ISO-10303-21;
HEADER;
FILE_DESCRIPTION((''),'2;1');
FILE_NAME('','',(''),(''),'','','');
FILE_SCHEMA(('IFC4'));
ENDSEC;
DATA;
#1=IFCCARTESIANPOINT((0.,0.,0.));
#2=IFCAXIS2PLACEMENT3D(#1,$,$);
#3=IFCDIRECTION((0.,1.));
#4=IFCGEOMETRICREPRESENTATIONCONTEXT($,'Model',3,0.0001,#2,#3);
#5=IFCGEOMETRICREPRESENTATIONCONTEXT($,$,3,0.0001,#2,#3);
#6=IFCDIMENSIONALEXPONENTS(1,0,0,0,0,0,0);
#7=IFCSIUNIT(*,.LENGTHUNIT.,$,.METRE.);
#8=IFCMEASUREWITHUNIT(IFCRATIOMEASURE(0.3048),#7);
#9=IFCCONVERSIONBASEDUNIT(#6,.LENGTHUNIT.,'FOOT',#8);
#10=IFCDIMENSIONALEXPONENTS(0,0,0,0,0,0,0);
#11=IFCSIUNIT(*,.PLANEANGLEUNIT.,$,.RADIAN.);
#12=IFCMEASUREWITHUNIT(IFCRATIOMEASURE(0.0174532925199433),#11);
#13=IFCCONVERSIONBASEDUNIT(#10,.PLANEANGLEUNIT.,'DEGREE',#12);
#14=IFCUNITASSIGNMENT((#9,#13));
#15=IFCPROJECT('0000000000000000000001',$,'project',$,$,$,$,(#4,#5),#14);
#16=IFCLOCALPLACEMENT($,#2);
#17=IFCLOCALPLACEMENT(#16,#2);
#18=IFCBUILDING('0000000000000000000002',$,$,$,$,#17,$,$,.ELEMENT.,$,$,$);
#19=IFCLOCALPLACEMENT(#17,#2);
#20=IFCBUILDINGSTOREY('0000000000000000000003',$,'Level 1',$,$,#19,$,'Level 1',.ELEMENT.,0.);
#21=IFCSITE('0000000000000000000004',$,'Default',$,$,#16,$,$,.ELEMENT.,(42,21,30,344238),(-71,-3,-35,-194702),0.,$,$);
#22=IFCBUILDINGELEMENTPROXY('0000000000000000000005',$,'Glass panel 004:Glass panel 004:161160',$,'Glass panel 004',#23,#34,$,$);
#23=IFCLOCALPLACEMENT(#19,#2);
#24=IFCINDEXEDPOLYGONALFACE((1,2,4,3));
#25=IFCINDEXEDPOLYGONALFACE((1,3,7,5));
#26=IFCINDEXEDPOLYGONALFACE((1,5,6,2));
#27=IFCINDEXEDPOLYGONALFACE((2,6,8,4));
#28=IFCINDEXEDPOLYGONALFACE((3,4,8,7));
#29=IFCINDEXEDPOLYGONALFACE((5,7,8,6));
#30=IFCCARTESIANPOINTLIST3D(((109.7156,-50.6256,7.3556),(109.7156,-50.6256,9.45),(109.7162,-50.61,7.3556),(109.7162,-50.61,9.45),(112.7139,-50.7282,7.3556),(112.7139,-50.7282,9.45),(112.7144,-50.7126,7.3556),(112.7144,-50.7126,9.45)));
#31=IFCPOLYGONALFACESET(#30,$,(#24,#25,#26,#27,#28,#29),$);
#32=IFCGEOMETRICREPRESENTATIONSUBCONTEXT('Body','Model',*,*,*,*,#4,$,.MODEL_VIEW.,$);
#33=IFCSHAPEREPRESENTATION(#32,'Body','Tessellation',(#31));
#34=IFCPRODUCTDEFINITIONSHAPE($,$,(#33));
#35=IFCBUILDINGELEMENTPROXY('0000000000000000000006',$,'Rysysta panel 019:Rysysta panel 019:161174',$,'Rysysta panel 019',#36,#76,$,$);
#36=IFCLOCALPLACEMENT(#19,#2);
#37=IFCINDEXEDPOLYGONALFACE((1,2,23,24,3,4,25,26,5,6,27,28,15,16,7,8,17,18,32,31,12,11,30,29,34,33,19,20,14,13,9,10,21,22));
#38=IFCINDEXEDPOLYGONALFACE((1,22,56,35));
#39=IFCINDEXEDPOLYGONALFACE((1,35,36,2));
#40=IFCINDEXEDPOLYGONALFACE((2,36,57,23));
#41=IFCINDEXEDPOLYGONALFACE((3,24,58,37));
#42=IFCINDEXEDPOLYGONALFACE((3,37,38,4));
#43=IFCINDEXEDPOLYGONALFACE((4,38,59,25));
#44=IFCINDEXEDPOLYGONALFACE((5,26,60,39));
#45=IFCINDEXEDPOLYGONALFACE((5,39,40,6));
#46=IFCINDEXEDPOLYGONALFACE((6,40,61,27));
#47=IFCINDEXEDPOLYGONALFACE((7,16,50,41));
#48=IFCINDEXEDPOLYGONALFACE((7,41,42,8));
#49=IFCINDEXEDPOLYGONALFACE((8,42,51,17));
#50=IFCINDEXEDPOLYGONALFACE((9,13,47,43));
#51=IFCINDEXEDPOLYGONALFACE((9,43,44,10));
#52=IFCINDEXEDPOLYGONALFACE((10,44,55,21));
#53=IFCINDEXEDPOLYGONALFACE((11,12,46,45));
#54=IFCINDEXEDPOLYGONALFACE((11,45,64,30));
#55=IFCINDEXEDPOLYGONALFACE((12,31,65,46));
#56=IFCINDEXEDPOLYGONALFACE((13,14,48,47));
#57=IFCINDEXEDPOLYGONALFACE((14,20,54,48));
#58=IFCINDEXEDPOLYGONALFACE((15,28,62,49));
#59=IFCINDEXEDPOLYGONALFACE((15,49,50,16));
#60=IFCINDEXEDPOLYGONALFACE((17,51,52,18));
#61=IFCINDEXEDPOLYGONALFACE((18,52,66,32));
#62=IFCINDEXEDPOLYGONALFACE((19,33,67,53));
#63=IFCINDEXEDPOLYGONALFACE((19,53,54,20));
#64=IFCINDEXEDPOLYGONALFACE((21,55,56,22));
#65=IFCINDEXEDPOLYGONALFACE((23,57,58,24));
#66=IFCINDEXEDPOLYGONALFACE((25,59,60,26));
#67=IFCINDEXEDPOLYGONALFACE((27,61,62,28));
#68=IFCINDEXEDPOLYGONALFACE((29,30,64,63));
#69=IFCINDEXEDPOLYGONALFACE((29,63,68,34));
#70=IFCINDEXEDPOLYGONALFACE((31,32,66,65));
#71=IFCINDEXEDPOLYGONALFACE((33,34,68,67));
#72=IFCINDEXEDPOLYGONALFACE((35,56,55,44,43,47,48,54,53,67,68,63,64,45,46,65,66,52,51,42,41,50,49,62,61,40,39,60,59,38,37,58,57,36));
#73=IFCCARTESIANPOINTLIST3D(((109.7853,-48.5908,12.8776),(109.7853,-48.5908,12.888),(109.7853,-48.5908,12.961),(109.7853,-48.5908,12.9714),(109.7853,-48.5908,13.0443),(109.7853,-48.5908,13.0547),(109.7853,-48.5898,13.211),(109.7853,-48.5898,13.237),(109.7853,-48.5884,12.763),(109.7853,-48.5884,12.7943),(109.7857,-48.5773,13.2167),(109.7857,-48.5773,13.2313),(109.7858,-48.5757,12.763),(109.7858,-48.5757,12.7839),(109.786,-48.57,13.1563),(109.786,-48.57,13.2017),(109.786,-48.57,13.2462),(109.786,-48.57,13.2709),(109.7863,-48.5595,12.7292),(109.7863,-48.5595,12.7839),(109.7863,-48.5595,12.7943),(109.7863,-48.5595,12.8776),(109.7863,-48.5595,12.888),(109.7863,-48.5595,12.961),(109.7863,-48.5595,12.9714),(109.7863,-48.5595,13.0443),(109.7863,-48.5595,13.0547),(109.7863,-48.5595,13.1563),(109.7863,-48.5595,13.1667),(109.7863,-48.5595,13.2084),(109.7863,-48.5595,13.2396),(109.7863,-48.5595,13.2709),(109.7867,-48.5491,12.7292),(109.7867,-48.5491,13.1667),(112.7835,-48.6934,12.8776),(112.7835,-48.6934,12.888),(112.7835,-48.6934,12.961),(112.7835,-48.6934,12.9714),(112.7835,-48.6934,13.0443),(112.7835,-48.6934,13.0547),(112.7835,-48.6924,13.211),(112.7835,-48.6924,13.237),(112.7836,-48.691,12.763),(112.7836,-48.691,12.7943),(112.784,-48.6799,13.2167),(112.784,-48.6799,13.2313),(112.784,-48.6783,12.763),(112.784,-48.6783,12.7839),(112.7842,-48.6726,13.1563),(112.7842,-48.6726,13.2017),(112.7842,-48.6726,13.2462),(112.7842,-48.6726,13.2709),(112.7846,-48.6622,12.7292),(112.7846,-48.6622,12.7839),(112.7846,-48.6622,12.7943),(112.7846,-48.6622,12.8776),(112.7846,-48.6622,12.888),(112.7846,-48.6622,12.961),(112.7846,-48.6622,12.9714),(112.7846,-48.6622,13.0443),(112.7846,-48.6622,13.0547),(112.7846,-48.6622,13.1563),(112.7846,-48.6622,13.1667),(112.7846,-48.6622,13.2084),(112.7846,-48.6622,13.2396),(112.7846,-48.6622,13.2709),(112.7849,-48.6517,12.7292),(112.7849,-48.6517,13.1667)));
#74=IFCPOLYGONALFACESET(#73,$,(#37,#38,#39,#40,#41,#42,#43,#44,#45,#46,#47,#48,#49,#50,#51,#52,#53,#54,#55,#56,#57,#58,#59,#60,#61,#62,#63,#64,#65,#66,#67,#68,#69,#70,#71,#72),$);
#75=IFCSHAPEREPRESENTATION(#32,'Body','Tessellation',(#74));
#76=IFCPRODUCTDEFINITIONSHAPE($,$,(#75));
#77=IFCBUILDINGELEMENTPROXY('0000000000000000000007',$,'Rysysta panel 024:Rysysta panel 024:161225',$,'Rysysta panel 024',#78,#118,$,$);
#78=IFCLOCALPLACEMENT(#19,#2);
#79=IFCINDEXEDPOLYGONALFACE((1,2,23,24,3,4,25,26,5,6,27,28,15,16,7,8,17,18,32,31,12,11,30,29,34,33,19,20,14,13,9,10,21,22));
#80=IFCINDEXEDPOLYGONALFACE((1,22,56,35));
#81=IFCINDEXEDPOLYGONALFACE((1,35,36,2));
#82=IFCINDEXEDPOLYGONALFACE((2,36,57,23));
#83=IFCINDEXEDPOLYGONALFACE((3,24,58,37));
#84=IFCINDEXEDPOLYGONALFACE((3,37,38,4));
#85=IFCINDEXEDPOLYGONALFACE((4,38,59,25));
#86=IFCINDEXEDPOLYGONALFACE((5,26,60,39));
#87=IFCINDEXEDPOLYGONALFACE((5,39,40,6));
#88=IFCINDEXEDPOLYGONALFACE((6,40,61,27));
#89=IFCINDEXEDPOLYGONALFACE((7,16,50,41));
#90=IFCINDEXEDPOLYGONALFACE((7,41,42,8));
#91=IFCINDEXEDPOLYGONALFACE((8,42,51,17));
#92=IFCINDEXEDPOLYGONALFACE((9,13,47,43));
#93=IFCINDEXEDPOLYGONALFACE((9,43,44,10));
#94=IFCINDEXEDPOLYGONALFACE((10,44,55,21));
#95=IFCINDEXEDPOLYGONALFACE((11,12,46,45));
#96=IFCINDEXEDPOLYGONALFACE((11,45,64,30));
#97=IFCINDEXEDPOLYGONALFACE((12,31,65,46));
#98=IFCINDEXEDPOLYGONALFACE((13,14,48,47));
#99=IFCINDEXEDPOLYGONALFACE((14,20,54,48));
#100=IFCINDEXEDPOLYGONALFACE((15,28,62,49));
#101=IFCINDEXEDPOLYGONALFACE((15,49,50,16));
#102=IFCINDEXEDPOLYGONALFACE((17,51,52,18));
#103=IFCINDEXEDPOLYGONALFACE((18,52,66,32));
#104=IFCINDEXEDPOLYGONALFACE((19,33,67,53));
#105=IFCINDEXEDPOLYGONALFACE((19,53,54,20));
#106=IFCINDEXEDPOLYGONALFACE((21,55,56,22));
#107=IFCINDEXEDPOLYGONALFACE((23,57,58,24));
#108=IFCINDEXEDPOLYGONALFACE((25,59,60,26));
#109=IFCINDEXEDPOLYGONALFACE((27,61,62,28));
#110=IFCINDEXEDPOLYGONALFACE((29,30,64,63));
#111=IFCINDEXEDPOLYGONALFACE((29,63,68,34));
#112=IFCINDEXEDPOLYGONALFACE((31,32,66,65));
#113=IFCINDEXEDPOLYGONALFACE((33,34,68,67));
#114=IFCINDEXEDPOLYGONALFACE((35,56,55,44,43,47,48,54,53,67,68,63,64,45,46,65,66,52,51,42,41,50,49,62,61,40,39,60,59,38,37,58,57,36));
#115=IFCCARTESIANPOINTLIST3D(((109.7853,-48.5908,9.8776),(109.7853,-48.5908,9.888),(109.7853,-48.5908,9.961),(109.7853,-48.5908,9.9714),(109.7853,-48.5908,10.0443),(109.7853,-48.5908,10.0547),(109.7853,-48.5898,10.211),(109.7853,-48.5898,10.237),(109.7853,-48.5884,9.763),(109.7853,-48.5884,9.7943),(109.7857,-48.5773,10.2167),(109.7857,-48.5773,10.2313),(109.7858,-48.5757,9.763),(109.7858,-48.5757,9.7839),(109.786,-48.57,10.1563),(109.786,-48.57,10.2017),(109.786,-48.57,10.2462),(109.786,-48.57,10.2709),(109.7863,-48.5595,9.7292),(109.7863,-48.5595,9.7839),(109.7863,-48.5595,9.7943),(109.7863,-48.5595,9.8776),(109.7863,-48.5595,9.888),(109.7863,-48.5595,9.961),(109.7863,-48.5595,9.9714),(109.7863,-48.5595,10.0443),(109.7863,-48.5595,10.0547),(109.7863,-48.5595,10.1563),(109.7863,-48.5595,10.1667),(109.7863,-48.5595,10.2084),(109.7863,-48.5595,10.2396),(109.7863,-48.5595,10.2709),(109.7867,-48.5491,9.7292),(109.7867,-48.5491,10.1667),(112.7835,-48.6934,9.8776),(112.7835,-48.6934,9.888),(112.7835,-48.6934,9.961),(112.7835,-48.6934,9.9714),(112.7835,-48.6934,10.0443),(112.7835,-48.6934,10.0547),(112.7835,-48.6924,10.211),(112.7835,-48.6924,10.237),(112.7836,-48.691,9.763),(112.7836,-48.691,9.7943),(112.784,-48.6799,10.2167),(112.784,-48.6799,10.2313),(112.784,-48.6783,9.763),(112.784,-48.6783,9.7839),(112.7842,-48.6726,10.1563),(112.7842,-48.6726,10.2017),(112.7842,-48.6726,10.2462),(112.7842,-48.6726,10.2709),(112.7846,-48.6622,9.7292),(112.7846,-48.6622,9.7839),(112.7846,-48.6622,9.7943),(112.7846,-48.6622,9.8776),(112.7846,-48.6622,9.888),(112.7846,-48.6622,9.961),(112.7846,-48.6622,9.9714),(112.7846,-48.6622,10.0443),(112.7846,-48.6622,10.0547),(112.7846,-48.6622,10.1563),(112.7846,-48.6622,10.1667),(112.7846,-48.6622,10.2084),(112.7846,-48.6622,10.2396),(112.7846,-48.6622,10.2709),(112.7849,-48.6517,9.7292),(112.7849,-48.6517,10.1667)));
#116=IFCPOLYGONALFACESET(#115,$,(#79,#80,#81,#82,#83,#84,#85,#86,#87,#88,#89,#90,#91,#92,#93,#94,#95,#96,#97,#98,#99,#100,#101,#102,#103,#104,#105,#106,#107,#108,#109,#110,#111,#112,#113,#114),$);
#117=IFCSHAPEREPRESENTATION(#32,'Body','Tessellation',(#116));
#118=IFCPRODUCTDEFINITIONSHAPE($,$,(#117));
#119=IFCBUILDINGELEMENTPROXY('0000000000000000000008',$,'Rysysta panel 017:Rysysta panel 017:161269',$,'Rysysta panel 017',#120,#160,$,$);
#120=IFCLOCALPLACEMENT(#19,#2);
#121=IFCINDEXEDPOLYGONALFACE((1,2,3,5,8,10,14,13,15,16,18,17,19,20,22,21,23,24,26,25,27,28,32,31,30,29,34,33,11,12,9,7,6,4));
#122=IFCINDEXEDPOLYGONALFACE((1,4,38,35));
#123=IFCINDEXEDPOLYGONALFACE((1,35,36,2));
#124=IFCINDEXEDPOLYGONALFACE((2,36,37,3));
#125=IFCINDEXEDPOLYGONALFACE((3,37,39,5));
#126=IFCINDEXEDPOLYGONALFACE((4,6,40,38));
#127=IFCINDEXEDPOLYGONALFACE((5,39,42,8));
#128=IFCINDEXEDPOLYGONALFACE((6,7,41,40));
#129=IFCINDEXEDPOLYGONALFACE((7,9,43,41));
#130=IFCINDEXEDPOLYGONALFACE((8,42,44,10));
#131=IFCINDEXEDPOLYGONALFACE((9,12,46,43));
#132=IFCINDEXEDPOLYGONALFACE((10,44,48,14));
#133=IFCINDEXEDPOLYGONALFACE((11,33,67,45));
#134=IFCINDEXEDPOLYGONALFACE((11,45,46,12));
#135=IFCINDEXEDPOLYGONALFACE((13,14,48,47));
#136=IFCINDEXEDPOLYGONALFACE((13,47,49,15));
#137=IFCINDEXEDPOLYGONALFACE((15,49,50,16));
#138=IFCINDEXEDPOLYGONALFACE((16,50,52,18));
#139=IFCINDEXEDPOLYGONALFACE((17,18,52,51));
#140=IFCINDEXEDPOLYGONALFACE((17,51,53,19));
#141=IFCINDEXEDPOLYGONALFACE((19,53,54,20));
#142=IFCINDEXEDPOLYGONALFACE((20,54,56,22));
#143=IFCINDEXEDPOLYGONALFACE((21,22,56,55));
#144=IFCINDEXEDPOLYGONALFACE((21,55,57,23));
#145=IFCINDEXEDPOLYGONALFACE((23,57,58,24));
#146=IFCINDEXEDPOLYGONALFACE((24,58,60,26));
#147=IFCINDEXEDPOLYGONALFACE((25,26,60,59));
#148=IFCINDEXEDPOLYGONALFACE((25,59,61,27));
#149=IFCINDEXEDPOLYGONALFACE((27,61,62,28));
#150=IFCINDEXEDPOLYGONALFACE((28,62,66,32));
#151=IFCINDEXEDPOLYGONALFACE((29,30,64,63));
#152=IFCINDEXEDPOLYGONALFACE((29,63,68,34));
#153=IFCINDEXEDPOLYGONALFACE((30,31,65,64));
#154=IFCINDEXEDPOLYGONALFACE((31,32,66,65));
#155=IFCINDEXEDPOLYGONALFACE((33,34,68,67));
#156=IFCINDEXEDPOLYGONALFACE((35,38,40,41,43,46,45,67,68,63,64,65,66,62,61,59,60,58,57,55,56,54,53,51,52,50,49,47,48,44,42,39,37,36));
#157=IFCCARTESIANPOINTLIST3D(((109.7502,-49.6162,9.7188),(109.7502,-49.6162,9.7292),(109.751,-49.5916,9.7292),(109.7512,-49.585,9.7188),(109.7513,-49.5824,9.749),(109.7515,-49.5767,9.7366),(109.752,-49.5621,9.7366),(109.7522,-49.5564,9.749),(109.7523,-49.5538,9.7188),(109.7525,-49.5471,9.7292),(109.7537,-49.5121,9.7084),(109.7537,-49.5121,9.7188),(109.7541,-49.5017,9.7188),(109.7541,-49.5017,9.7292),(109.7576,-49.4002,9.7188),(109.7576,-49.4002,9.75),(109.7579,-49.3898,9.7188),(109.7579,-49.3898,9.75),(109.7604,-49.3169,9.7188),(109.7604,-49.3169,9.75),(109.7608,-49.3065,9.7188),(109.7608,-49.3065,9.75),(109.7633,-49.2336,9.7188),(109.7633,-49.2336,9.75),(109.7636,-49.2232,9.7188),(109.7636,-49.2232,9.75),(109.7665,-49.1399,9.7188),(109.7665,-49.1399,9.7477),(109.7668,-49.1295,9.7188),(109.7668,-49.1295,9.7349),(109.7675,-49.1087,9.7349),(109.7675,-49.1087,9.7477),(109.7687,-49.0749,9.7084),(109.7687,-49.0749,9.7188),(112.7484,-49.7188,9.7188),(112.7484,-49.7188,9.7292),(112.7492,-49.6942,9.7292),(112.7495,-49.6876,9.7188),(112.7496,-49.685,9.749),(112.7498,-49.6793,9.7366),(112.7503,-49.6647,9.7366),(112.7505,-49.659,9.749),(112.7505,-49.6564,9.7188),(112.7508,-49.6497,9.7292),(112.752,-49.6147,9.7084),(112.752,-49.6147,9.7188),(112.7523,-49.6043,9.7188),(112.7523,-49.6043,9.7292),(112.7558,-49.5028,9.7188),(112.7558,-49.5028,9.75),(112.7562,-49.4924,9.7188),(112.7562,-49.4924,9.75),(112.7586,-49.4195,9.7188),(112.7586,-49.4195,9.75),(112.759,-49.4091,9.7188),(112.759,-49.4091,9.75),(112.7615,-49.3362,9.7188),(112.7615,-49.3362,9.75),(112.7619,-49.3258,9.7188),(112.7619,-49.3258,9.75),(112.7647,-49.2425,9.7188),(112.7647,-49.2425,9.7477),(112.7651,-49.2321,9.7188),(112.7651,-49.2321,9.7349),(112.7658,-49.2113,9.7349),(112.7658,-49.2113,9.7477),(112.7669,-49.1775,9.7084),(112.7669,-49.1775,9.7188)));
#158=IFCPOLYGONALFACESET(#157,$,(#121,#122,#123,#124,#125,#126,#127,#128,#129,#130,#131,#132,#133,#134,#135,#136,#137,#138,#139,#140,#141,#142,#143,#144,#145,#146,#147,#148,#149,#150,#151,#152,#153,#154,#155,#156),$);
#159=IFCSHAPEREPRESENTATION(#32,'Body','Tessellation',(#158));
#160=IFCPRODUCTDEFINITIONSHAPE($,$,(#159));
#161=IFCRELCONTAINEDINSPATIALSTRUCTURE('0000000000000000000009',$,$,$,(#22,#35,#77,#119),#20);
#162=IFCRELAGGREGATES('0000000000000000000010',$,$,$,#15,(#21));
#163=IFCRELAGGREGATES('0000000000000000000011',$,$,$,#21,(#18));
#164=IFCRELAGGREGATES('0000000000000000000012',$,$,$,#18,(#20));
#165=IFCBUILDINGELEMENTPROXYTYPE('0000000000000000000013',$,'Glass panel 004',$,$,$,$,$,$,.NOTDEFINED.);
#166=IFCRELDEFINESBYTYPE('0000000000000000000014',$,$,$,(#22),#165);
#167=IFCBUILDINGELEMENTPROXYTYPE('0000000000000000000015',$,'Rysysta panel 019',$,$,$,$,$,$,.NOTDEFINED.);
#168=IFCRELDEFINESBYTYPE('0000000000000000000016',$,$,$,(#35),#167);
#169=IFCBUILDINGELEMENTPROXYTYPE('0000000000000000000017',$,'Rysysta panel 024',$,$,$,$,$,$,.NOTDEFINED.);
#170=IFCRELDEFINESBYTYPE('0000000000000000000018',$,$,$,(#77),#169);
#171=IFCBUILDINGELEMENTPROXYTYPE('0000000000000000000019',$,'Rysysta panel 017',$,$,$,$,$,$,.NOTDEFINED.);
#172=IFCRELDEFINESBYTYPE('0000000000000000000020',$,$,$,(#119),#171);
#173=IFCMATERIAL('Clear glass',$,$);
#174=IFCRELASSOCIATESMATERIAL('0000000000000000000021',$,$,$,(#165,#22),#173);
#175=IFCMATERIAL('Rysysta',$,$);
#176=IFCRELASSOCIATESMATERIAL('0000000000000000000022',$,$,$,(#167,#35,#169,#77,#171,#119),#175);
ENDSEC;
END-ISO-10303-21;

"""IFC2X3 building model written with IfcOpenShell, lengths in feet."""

from ifc_helpers import new_model, entity, si_unit, converted_unit, direction, frame, origin, origin_2d_with_axis, place, context, subcontext, project, spatial, polyline, rectangle, outline, extrude, source, transform, mapped, material, type_object, type_shapes, element, save


model = new_model("IFC2X3")

# Units and contexts
model_context = context("Model", 3, precision=0.0001, world=origin(), true_north=direction((0.0, 1.0)))
context_of_model = context(None, 3, precision=0.0001, world=origin(), true_north=direction((0.0, 1.0)))
body_context = subcontext(model_context, "Body", "Model", "MODEL_VIEW")
ifc_project = project(units=[converted_unit("LENGTHUNIT", "FOOT", entity("IfcRatioMeasure", 0.3048), si_unit("LENGTHUNIT", "METRE"), dimensions=[1, 0, 0, 0, 0, 0, 0]), converted_unit("PLANEANGLEUNIT", "DEGREE", entity("IfcRatioMeasure", 0.0174532925199433), si_unit("PLANEANGLEUNIT", "RADIAN"), dimensions=[0, 0, 0, 0, 0, 0, 0])], contexts=[model_context, context_of_model])

# Site, building, storey
site_placement = place(None, origin())
site = spatial("IfcSite", under=ifc_project, at=site_placement, Name="Default", CompositionType="ELEMENT", RefLatitude=(42, 21, 30, 344238), RefLongitude=(-71, -3, -35, -194702), RefElevation=0.0)
building_placement = place(site_placement, origin())
building = spatial("IfcBuilding", under=site, at=building_placement, CompositionType="ELEMENT")
storey_placement = place(building_placement, origin())
storey = spatial("IfcBuildingStorey", under=building, at=storey_placement, Name="Level 1", LongName="Level 1", CompositionType="ELEMENT", Elevation=0.0)

# Building element proxies
ifc_material_1 = material(Name="Rysysta")
ifc_material_2 = material(Name="Clear glass")
building_element_proxy_type_1 = type_object("IfcBuildingElementProxyType", Name="Glass panel 004", PredefinedType="NOTDEFINED", material=ifc_material_2)
shared_shape_1 = source(origin(), body_context, "Body", "SweptSolid", [
    extrude(rectangle(XDim=3.0, YDim=0.0156, at=origin_2d_with_axis()), frame((111.215, -50.6691, 7.3556), z_axis=(0.0, 0.0, 1.0), x_axis=(-0.999415, 0.034202, 0.0)), (0.0, 0.0, 1.0), 2.0943),
])
type_shapes(building_element_proxy_type_1, [shared_shape_1])
proxy_1_placement = place(storey_placement, origin())
element("IfcBuildingElementProxy", 1, at=proxy_1_placement, inside=storey, type_object=building_element_proxy_type_1, material=ifc_material_2, Name="Glass panel 004:Glass panel 004:161160", ObjectType="Glass panel 004", context=body_context, shape_type="MappedRepresentation", body=[
    mapped(shared_shape_1, transform((0.0, 0.0, 0.0), scale=1.0)),
])
building_element_proxy_type_2 = type_object("IfcBuildingElementProxyType", Name="Rysysta panel 019", PredefinedType="NOTDEFINED", material=ifc_material_1)
shared_shape_2 = source(origin(), body_context, "Body", "SweptSolid", [
    extrude(outline(polyline([(-0.022, 0.1457), (-0.022, -0.2918), (-0.0116, -0.2918), (-0.0116, -0.2371), (0.0045, -0.2371), (0.0045, -0.258), (0.0173, -0.258), (0.0173, -0.2267), (-0.0116, -0.2267), (-0.0116, -0.1434), (0.0196, -0.1434), (0.0196, -0.133), (-0.0116, -0.133), (-0.0116, -0.06), (0.0196, -0.06), (0.0196, -0.0496), (-0.0116, -0.0496), (-0.0116, 0.0233), (0.0196, 0.0233), (0.0196, 0.0337), (-0.0116, 0.0337), (-0.0116, 0.1353), (-0.0012, 0.1353), (-0.0012, 0.1807), (0.0186, 0.1899), (0.0186, 0.216), (-0.0012, 0.2252), (-0.0012, 0.2498), (-0.0116, 0.2498), (-0.0116, 0.2186), (0.0062, 0.2103), (0.0062, 0.1956), (-0.0116, 0.1873), (-0.0116, 0.1457), (-0.022, 0.1457)])), frame((109.7859, -48.5711, 13.021), z_axis=(-0.999415, 0.034202, 0.0), x_axis=(-0.034202, -0.999415, 0.0)), (0.0, 0.0, -1.0), 3.0),
])
type_shapes(building_element_proxy_type_2, [shared_shape_2])
proxy_2_placement = place(storey_placement, origin())
element("IfcBuildingElementProxy", 2, at=proxy_2_placement, inside=storey, type_object=building_element_proxy_type_2, material=ifc_material_1, Name="Rysysta panel 019:Rysysta panel 019:161174", ObjectType="Rysysta panel 019", context=body_context, shape_type="MappedRepresentation", body=[
    mapped(shared_shape_2, transform((0.0, 0.0, 0.0), scale=1.0)),
])
building_element_proxy_type_3 = type_object("IfcBuildingElementProxyType", Name="Rysysta panel 024", PredefinedType="NOTDEFINED", material=ifc_material_1)
shared_shape_3 = source(origin(), body_context, "Body", "SweptSolid", [
    extrude(outline(polyline([(-0.022, 0.1457), (-0.022, -0.2918), (-0.0116, -0.2918), (-0.0116, -0.2371), (0.0045, -0.2371), (0.0045, -0.258), (0.0173, -0.258), (0.0173, -0.2267), (-0.0116, -0.2267), (-0.0116, -0.1434), (0.0196, -0.1434), (0.0196, -0.133), (-0.0116, -0.133), (-0.0116, -0.06), (0.0196, -0.06), (0.0196, -0.0496), (-0.0116, -0.0496), (-0.0116, 0.0233), (0.0196, 0.0233), (0.0196, 0.0337), (-0.0116, 0.0337), (-0.0116, 0.1353), (-0.0012, 0.1353), (-0.0012, 0.1807), (0.0186, 0.1899), (0.0186, 0.216), (-0.0012, 0.2252), (-0.0012, 0.2498), (-0.0116, 0.2498), (-0.0116, 0.2186), (0.0062, 0.2103), (0.0062, 0.1956), (-0.0116, 0.1873), (-0.0116, 0.1457), (-0.022, 0.1457)])), frame((109.7859, -48.5711, 10.021), z_axis=(-0.999415, 0.034202, 0.0), x_axis=(-0.034202, -0.999415, 0.0)), (0.0, 0.0, -1.0), 3.0),
])
type_shapes(building_element_proxy_type_3, [shared_shape_3])
proxy_3_placement = place(storey_placement, origin())
element("IfcBuildingElementProxy", 3, at=proxy_3_placement, inside=storey, type_object=building_element_proxy_type_3, material=ifc_material_1, Name="Rysysta panel 024:Rysysta panel 024:161225", ObjectType="Rysysta panel 024", context=body_context, shape_type="MappedRepresentation", body=[
    mapped(shared_shape_3, transform((0.0, 0.0, 0.0), scale=1.0)),
])
building_element_proxy_type_4 = type_object("IfcBuildingElementProxyType", Name="Rysysta panel 017", PredefinedType="NOTDEFINED", material=ifc_material_1)
shared_shape_4 = source(origin(), body_context, "Body", "SweptSolid", [
    extrude(outline(polyline([(-0.2918, -0.0116), (-0.2918, -0.022), (0.1457, -0.022), (0.1457, -0.0116), (0.1873, -0.0116), (0.1956, 0.0062), (0.2103, 0.0062), (0.2186, -0.0116), (0.2498, -0.0116), (0.2498, -0.0012), (0.2252, -0.0012), (0.216, 0.0186), (0.1899, 0.0186), (0.1807, -0.0012), (0.1353, -0.0012), (0.1353, -0.0116), (0.0337, -0.0116), (0.0337, 0.0196), (0.0233, 0.0196), (0.0233, -0.0116), (-0.0496, -0.0116), (-0.0496, 0.0196), (-0.06, 0.0196), (-0.06, -0.0116), (-0.133, -0.0116), (-0.133, 0.0196), (-0.1434, 0.0196), (-0.1434, -0.0116), (-0.2267, -0.0116), (-0.2267, 0.0173), (-0.258, 0.0173), (-0.258, 0.0045), (-0.2371, 0.0045), (-0.2371, -0.0116), (-0.2918, -0.0116)])), frame((109.7587, -49.3665, 9.7304), z_axis=(-0.999415, 0.034202, 0.0), x_axis=(-0.034202, -0.999415, 0.0)), (0.0, 0.0, -1.0), 3.0),
])
type_shapes(building_element_proxy_type_4, [shared_shape_4])
proxy_4_placement = place(storey_placement, origin())
element("IfcBuildingElementProxy", 4, at=proxy_4_placement, inside=storey, type_object=building_element_proxy_type_4, material=ifc_material_1, Name="Rysysta panel 017:Rysysta panel 017:161269", ObjectType="Rysysta panel 017", context=body_context, shape_type="MappedRepresentation", body=[
    mapped(shared_shape_4, transform((0.0, 0.0, 0.0), scale=1.0)),
])

save(model, "model.ifc")
